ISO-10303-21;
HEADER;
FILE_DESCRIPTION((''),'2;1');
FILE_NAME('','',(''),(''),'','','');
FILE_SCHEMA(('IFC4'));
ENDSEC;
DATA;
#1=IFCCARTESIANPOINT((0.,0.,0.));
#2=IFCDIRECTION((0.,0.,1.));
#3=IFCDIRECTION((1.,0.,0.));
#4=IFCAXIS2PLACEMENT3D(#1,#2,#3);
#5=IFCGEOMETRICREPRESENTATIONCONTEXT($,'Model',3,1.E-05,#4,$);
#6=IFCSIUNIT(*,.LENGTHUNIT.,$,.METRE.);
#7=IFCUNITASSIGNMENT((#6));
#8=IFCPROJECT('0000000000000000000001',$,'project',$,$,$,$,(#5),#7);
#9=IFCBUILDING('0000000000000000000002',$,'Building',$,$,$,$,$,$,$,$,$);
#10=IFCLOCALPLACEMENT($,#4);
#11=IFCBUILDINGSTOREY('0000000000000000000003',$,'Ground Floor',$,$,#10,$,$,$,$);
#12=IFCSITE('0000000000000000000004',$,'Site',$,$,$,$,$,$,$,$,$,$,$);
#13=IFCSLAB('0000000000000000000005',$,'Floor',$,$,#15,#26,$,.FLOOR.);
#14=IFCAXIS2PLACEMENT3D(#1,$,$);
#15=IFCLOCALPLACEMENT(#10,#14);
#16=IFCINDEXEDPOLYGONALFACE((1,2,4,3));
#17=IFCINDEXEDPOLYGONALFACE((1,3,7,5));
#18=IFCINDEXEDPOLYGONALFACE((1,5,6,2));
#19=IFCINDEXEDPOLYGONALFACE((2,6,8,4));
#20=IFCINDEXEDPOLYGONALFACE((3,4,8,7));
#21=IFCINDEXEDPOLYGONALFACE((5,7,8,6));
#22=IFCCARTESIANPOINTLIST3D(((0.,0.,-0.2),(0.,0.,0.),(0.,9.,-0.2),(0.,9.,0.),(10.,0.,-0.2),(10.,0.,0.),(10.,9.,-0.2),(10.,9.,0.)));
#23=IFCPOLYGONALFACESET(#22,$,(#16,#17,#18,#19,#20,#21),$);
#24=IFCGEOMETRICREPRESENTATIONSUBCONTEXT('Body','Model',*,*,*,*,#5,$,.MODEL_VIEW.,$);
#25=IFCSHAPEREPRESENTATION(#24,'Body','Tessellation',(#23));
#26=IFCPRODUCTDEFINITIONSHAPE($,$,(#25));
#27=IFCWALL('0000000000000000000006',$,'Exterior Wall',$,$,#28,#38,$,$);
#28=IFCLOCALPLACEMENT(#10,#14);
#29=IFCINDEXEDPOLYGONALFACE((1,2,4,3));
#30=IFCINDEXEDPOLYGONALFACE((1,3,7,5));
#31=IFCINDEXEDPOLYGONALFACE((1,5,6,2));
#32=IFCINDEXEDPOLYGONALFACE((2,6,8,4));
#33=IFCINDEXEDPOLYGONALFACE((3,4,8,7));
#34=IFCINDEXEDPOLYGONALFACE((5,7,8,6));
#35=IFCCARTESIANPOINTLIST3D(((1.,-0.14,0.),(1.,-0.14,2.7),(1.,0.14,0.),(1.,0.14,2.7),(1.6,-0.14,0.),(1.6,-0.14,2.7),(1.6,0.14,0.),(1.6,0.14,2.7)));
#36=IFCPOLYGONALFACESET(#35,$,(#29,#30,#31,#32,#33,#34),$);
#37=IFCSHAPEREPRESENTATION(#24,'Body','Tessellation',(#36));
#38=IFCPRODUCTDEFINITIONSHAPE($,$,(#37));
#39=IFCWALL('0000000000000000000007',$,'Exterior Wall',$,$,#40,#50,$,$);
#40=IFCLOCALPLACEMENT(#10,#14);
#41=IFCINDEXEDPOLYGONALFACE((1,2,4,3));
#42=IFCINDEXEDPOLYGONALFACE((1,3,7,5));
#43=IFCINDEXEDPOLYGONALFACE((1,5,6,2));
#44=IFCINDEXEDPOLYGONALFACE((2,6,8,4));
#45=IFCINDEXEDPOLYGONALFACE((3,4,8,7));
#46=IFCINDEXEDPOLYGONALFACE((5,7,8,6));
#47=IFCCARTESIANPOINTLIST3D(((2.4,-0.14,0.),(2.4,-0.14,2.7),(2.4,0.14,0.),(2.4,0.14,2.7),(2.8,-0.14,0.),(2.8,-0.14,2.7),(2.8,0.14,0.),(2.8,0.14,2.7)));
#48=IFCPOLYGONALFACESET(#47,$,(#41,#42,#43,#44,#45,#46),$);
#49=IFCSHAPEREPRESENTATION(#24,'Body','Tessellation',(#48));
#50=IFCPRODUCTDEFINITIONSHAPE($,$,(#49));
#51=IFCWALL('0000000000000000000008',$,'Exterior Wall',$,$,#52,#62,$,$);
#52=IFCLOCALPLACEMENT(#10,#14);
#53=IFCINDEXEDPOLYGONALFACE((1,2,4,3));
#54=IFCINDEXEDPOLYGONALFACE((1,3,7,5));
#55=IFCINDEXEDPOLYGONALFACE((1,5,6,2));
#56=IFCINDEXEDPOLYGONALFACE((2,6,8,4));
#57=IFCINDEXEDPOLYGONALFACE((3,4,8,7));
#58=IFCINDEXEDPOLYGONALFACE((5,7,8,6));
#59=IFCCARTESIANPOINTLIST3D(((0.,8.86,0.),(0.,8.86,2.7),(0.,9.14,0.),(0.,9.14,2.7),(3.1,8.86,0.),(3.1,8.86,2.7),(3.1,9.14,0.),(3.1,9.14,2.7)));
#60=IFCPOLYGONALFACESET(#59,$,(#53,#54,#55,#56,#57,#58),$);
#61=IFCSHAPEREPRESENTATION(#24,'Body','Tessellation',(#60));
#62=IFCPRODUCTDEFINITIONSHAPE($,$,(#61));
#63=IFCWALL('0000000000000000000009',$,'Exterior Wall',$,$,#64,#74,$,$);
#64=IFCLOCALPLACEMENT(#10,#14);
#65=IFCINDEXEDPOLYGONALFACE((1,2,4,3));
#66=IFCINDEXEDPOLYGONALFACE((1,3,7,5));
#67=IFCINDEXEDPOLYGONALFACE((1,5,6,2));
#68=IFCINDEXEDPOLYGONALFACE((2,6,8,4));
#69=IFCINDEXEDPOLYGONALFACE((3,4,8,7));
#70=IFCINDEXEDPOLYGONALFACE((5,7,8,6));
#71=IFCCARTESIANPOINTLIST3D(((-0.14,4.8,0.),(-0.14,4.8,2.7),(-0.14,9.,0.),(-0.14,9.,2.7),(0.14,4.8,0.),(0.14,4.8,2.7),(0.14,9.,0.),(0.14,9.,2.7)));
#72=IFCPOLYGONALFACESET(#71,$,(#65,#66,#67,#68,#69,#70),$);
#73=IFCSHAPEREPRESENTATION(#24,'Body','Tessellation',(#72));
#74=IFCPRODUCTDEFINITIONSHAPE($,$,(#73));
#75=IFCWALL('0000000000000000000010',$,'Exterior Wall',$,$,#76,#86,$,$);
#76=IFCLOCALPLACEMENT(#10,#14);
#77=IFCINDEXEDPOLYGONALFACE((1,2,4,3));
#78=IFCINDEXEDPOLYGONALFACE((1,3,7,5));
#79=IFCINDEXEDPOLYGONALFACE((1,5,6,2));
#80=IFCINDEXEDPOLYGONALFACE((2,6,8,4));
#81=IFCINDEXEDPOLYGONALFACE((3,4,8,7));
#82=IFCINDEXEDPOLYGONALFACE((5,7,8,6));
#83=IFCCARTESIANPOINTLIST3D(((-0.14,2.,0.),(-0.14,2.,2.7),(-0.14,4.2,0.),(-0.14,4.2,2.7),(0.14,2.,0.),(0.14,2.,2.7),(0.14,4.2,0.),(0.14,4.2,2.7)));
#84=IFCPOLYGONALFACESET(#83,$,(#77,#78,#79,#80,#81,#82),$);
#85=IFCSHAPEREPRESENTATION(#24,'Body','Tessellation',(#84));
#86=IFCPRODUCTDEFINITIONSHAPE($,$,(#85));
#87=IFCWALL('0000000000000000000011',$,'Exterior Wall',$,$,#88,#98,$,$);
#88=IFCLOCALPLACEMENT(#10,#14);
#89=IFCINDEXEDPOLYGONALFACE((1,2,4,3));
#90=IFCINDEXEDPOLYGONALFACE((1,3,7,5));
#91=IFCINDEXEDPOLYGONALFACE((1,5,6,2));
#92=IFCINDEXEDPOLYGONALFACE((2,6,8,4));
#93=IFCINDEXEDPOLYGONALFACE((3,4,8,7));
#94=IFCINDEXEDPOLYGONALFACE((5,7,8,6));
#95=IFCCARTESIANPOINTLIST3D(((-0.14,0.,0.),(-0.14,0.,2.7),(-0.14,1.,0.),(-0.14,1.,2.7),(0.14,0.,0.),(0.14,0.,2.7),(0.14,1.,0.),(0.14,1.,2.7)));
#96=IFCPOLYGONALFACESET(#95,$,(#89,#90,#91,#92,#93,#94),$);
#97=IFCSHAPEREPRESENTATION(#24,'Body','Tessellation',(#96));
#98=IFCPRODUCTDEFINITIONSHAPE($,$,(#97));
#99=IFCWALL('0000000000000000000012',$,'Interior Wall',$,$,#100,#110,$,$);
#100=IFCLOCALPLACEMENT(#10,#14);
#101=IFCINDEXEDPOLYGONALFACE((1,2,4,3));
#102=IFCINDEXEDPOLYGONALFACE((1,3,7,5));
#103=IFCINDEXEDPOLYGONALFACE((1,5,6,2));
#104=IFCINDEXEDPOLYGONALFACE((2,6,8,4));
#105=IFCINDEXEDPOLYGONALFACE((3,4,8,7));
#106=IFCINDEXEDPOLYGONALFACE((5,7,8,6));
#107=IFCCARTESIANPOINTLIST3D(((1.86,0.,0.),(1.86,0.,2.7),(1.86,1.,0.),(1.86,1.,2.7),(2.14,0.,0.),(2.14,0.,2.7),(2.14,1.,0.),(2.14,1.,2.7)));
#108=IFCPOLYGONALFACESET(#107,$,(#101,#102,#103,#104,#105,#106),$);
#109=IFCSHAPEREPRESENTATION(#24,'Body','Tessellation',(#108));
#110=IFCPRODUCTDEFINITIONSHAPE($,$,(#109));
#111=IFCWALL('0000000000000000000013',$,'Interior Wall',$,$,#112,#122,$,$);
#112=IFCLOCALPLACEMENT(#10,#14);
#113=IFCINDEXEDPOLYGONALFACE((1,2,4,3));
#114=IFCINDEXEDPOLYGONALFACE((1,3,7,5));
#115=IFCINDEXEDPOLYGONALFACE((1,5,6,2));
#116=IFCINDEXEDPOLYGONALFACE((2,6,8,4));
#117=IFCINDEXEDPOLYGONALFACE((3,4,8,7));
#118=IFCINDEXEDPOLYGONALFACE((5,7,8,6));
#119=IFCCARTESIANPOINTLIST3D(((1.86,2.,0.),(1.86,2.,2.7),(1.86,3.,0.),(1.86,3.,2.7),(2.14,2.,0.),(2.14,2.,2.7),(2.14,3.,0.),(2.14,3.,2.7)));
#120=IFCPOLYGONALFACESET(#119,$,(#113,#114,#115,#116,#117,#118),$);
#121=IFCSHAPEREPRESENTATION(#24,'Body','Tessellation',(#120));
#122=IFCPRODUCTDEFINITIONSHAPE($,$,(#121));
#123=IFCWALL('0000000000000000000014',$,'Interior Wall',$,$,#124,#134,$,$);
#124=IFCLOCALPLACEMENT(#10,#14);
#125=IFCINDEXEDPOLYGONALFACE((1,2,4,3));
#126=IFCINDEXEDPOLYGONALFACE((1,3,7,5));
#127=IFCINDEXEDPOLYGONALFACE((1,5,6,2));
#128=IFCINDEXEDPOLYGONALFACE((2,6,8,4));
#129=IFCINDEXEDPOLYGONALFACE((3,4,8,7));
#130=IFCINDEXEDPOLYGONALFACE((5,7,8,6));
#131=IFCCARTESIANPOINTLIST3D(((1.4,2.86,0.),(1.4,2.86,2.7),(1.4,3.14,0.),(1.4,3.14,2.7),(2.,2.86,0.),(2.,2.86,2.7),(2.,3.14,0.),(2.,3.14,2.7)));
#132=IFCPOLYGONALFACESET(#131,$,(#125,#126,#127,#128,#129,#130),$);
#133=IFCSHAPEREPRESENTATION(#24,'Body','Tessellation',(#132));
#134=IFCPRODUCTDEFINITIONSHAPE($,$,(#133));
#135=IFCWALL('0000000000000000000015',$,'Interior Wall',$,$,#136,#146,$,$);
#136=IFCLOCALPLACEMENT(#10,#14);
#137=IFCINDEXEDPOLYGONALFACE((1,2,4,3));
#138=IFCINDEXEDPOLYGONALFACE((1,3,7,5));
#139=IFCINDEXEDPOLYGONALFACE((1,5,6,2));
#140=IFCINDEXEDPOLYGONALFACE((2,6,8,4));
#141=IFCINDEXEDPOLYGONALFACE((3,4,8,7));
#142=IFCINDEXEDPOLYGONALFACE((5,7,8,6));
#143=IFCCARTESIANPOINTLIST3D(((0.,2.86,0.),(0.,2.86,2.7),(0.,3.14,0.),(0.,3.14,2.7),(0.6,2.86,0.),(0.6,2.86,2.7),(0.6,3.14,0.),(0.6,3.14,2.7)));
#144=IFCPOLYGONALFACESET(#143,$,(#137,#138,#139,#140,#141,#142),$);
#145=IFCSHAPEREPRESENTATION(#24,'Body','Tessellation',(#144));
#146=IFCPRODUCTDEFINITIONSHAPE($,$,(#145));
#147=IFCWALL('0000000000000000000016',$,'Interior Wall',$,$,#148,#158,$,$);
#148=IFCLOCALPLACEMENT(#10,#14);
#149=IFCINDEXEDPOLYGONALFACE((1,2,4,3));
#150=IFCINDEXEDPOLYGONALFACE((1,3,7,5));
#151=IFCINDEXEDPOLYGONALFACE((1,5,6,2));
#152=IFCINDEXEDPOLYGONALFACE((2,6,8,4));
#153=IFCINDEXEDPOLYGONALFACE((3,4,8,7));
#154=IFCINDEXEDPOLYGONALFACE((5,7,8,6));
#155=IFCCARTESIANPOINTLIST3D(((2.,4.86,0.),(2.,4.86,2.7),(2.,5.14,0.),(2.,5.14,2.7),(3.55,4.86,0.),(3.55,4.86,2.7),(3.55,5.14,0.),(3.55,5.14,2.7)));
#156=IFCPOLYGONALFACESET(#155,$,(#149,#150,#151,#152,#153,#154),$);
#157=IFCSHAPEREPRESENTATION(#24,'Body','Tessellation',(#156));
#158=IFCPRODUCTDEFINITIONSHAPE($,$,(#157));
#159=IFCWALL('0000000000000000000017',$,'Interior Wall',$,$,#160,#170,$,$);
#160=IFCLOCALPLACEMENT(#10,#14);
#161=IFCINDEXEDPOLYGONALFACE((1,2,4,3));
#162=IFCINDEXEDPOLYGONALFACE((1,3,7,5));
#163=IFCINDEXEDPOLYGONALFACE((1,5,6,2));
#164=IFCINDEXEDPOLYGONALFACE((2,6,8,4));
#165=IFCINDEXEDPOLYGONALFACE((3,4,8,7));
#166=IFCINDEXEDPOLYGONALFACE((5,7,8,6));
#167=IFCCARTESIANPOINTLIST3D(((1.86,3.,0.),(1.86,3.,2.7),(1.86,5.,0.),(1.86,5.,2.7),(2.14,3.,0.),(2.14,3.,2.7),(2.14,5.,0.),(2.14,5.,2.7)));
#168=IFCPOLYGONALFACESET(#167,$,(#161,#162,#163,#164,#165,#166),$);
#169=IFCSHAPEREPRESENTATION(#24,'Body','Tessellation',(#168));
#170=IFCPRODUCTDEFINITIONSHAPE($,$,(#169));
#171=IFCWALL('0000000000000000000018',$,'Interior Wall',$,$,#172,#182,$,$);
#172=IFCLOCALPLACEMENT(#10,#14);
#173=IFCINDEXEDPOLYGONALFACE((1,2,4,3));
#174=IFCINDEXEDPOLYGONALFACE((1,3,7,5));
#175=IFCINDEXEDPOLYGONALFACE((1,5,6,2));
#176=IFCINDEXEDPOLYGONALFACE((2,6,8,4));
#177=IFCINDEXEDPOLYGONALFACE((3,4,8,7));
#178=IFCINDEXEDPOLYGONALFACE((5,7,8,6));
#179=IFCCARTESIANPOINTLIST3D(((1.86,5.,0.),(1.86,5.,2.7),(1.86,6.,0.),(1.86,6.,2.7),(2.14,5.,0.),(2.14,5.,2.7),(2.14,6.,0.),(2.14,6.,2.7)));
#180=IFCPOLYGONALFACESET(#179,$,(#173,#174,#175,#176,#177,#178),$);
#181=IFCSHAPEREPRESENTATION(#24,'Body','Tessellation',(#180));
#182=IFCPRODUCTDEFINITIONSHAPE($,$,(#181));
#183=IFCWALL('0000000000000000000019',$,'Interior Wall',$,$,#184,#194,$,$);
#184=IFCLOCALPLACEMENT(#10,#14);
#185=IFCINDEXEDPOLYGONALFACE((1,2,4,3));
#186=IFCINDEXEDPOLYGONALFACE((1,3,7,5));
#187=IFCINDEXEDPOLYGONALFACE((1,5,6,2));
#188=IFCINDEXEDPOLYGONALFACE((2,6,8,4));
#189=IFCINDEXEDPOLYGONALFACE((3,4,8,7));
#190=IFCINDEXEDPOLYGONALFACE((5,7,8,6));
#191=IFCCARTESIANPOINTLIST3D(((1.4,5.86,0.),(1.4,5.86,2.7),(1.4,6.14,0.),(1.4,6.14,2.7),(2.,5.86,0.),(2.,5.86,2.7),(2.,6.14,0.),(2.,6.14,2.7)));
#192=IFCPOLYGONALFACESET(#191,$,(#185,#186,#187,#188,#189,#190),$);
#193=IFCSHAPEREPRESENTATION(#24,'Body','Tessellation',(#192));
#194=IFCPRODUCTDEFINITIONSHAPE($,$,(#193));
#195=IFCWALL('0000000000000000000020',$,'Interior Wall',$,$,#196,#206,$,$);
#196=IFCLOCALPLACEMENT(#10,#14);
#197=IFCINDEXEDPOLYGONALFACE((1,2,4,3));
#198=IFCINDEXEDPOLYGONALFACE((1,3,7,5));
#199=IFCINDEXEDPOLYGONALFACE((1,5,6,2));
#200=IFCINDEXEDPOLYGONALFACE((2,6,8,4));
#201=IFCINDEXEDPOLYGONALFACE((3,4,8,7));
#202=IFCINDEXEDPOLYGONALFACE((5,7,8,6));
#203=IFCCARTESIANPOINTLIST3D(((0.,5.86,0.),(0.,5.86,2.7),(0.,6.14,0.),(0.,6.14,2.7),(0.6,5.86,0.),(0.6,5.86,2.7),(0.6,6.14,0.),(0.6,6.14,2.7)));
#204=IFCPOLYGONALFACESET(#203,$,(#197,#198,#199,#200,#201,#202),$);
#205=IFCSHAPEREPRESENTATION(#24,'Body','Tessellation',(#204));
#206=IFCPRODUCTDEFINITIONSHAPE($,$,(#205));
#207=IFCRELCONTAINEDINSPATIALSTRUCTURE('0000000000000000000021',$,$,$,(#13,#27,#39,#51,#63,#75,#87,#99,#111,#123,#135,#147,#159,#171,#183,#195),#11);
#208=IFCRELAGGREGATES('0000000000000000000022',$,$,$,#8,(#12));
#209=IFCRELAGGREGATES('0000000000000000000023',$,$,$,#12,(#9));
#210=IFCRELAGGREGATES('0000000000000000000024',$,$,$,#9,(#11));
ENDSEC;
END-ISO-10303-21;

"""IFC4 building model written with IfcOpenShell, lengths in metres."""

from ifc_helpers import new_model, si_unit, frame, origin_with_axes, place, context, subcontext, project, spatial, indexed_curve, outline, extrude, element, save


model = new_model("IFC4")

# Units and contexts
model_context = context("Model", 3, precision=1e-05, world=origin_with_axes())
body_context = subcontext(model_context, "Body", "Model", "MODEL_VIEW")
ifc_project = project(units=[si_unit("LENGTHUNIT", "METRE")], contexts=[model_context])

# Site, building, storey
site = spatial("IfcSite", under=ifc_project, Name="Site")
building = spatial("IfcBuilding", under=site, Name="Building")
storey_placement = place(None, origin_with_axes())
storey = spatial("IfcBuildingStorey", under=building, at=storey_placement, Name="Ground Floor")

# Slab
slab_placement = place(storey_placement, frame((0.0, 0.0, -0.2), z_axis=(0.0, 0.0, 1.0), x_axis=(1.0, 0.0, 0.0)))
element("IfcSlab", 1, at=slab_placement, inside=storey, Name="Floor", PredefinedType="FLOOR", context=body_context, shape_type="SweptSolid", body=[
    extrude(outline(indexed_curve([(0.0, 0.0), (10.0, 0.0), (10.0, 9.0), (0.0, 9.0)])), None, (0.0, 0.0, 1.0), 0.2),
])

# Walls
wall_1_placement = place(storey_placement, frame((1.0, 0.0, 0.0), z_axis=(0.0, 0.0, 1.0), x_axis=(1.0, 0.0, 0.0)))
element("IfcWall", 2, at=wall_1_placement, inside=storey, Name="Exterior Wall", context=body_context, shape_type="SweptSolid", body=[
    extrude(outline(indexed_curve([(0.0, 0.0), (0.0, 0.28), (0.6, 0.28), (0.6, 0.0), (0.0, 0.0)], self_intersect=False)), frame((0.0, -0.14, 0.0), z_axis=(0.0, 0.0, 1.0), x_axis=(1.0, 0.0, 0.0)), (0.0, 0.0, 1.0), 2.7),
])
wall_2_placement = place(storey_placement, frame((2.4, 0.0, 0.0), z_axis=(0.0, 0.0, 1.0), x_axis=(1.0, 0.0, 0.0)))
element("IfcWall", 3, at=wall_2_placement, inside=storey, Name="Exterior Wall", context=body_context, shape_type="SweptSolid", body=[
    extrude(outline(indexed_curve([(0.0, 0.0), (0.0, 0.28), (0.4, 0.28), (0.4, 0.0), (0.0, 0.0)], self_intersect=False)), frame((0.0, -0.14, 0.0), z_axis=(0.0, 0.0, 1.0), x_axis=(1.0, 0.0, 0.0)), (0.0, 0.0, 1.0), 2.7),
])
wall_3_placement = place(storey_placement, frame((3.1, 9.0, 0.0), z_axis=(0.0, 0.0, 1.0), x_axis=(-1.0, 0.0, 0.0)))
element("IfcWall", 4, at=wall_3_placement, inside=storey, Name="Exterior Wall", context=body_context, shape_type="SweptSolid", body=[
    extrude(outline(indexed_curve([(0.0, 0.0), (0.0, 0.28), (3.1, 0.28), (3.1, 0.0), (0.0, 0.0)], self_intersect=False)), frame((0.0, -0.14, 0.0), z_axis=(0.0, 0.0, 1.0), x_axis=(1.0, 0.0, 0.0)), (0.0, 0.0, 1.0), 2.7),
])
wall_4_placement = place(storey_placement, frame((0.0, 9.0, 0.0), z_axis=(0.0, 0.0, 1.0), x_axis=(0.0, -1.0, 0.0)))
element("IfcWall", 5, at=wall_4_placement, inside=storey, Name="Exterior Wall", context=body_context, shape_type="SweptSolid", body=[
    extrude(outline(indexed_curve([(0.0, 0.0), (0.0, 0.28), (4.2, 0.28), (4.2, 0.0), (0.0, 0.0)], self_intersect=False)), frame((0.0, -0.14, 0.0), z_axis=(0.0, 0.0, 1.0), x_axis=(1.0, 0.0, 0.0)), (0.0, 0.0, 1.0), 2.7),
])
wall_5_placement = place(storey_placement, frame((0.0, 4.2, 0.0), z_axis=(0.0, 0.0, 1.0), x_axis=(0.0, -1.0, 0.0)))
element("IfcWall", 6, at=wall_5_placement, inside=storey, Name="Exterior Wall", context=body_context, shape_type="SweptSolid", body=[
    extrude(outline(indexed_curve([(0.0, 0.0), (0.0, 0.28), (2.2, 0.28), (2.2, 0.0), (0.0, 0.0)], self_intersect=False)), frame((0.0, -0.14, 0.0), z_axis=(0.0, 0.0, 1.0), x_axis=(1.0, 0.0, 0.0)), (0.0, 0.0, 1.0), 2.7),
])
for number, where, z_axis, x_axis, name in (
    (7, (0.0, 1.0, 0.0), (0.0, 0.0, 1.0), (0.0, -1.0, 0.0), "Exterior Wall"),
    (8, (2.0, 0.0, 0.0), (0.0, 0.0, 1.0), (0.0, 1.0, 0.0), "Interior Wall"),
    (9, (2.0, 2.0, 0.0), (0.0, 0.0, 1.0), (0.0, 1.0, 0.0), "Interior Wall"),
):
    element("IfcWall", number, at=place(storey_placement, frame(where, z_axis=z_axis, x_axis=x_axis)), inside=storey, Name=name, context=body_context, shape_type="SweptSolid", body=[
        extrude(outline(indexed_curve([(0.0, 0.0), (0.0, 0.28), (1.0, 0.28), (1.0, 0.0), (0.0, 0.0)], self_intersect=False)), frame((0.0, -0.14, 0.0), z_axis=(0.0, 0.0, 1.0), x_axis=(1.0, 0.0, 0.0)), (0.0, 0.0, 1.0), 2.7),
    ])
for number, where, z_axis, x_axis, name in (
    (10, (2.0, 3.0, 0.0), (0.0, 0.0, 1.0), (-1.0, 0.0, 0.0), "Interior Wall"),
    (11, (0.6, 3.0, 0.0), (0.0, 0.0, 1.0), (-1.0, 0.0, 0.0), "Interior Wall"),
):
    element("IfcWall", number, at=place(storey_placement, frame(where, z_axis=z_axis, x_axis=x_axis)), inside=storey, Name=name, context=body_context, shape_type="SweptSolid", body=[
        extrude(outline(indexed_curve([(0.0, 0.0), (0.0, 0.28), (0.6, 0.28), (0.6, 0.0), (0.0, 0.0)], self_intersect=False)), frame((0.0, -0.14, 0.0), z_axis=(0.0, 0.0, 1.0), x_axis=(1.0, 0.0, 0.0)), (0.0, 0.0, 1.0), 2.7),
    ])
wall_6_placement = place(storey_placement, frame((3.55, 5.0, 0.0), z_axis=(0.0, 0.0, 1.0), x_axis=(-1.0, 0.0, 0.0)))
element("IfcWall", 12, at=wall_6_placement, inside=storey, Name="Interior Wall", context=body_context, shape_type="SweptSolid", body=[
    extrude(outline(indexed_curve([(0.0, 0.0), (0.0, 0.28), (1.55, 0.28), (1.55, 0.0), (0.0, 0.0)], self_intersect=False)), frame((0.0, -0.14, 0.0), z_axis=(0.0, 0.0, 1.0), x_axis=(1.0, 0.0, 0.0)), (0.0, 0.0, 1.0), 2.7),
])
wall_7_placement = place(storey_placement, frame((2.0, 5.0, 0.0), z_axis=(0.0, 0.0, 1.0), x_axis=(0.0, -1.0, 0.0)))
element("IfcWall", 13, at=wall_7_placement, inside=storey, Name="Interior Wall", context=body_context, shape_type="SweptSolid", body=[
    extrude(outline(indexed_curve([(0.0, 0.0), (0.0, 0.28), (2.0, 0.28), (2.0, 0.0), (0.0, 0.0)], self_intersect=False)), frame((0.0, -0.14, 0.0), z_axis=(0.0, 0.0, 1.0), x_axis=(1.0, 0.0, 0.0)), (0.0, 0.0, 1.0), 2.7),
])
wall_8_placement = place(storey_placement, frame((2.0, 5.0, 0.0), z_axis=(0.0, 0.0, 1.0), x_axis=(0.0, 1.0, 0.0)))
element("IfcWall", 14, at=wall_8_placement, inside=storey, Name="Interior Wall", context=body_context, shape_type="SweptSolid", body=[
    extrude(outline(indexed_curve([(0.0, 0.0), (0.0, 0.28), (1.0, 0.28), (1.0, 0.0), (0.0, 0.0)], self_intersect=False)), frame((0.0, -0.14, 0.0), z_axis=(0.0, 0.0, 1.0), x_axis=(1.0, 0.0, 0.0)), (0.0, 0.0, 1.0), 2.7),
])
for number, where, z_axis, x_axis, name in (
    (15, (2.0, 6.0, 0.0), (0.0, 0.0, 1.0), (-1.0, 0.0, 0.0), "Interior Wall"),
    (16, (0.6, 6.0, 0.0), (0.0, 0.0, 1.0), (-1.0, 0.0, 0.0), "Interior Wall"),
):
    element("IfcWall", number, at=place(storey_placement, frame(where, z_axis=z_axis, x_axis=x_axis)), inside=storey, Name=name, context=body_context, shape_type="SweptSolid", body=[
        extrude(outline(indexed_curve([(0.0, 0.0), (0.0, 0.28), (0.6, 0.28), (0.6, 0.0), (0.0, 0.0)], self_intersect=False)), frame((0.0, -0.14, 0.0), z_axis=(0.0, 0.0, 1.0), x_axis=(1.0, 0.0, 0.0)), (0.0, 0.0, 1.0), 2.7),
    ])

save(model, "model.ifc")
